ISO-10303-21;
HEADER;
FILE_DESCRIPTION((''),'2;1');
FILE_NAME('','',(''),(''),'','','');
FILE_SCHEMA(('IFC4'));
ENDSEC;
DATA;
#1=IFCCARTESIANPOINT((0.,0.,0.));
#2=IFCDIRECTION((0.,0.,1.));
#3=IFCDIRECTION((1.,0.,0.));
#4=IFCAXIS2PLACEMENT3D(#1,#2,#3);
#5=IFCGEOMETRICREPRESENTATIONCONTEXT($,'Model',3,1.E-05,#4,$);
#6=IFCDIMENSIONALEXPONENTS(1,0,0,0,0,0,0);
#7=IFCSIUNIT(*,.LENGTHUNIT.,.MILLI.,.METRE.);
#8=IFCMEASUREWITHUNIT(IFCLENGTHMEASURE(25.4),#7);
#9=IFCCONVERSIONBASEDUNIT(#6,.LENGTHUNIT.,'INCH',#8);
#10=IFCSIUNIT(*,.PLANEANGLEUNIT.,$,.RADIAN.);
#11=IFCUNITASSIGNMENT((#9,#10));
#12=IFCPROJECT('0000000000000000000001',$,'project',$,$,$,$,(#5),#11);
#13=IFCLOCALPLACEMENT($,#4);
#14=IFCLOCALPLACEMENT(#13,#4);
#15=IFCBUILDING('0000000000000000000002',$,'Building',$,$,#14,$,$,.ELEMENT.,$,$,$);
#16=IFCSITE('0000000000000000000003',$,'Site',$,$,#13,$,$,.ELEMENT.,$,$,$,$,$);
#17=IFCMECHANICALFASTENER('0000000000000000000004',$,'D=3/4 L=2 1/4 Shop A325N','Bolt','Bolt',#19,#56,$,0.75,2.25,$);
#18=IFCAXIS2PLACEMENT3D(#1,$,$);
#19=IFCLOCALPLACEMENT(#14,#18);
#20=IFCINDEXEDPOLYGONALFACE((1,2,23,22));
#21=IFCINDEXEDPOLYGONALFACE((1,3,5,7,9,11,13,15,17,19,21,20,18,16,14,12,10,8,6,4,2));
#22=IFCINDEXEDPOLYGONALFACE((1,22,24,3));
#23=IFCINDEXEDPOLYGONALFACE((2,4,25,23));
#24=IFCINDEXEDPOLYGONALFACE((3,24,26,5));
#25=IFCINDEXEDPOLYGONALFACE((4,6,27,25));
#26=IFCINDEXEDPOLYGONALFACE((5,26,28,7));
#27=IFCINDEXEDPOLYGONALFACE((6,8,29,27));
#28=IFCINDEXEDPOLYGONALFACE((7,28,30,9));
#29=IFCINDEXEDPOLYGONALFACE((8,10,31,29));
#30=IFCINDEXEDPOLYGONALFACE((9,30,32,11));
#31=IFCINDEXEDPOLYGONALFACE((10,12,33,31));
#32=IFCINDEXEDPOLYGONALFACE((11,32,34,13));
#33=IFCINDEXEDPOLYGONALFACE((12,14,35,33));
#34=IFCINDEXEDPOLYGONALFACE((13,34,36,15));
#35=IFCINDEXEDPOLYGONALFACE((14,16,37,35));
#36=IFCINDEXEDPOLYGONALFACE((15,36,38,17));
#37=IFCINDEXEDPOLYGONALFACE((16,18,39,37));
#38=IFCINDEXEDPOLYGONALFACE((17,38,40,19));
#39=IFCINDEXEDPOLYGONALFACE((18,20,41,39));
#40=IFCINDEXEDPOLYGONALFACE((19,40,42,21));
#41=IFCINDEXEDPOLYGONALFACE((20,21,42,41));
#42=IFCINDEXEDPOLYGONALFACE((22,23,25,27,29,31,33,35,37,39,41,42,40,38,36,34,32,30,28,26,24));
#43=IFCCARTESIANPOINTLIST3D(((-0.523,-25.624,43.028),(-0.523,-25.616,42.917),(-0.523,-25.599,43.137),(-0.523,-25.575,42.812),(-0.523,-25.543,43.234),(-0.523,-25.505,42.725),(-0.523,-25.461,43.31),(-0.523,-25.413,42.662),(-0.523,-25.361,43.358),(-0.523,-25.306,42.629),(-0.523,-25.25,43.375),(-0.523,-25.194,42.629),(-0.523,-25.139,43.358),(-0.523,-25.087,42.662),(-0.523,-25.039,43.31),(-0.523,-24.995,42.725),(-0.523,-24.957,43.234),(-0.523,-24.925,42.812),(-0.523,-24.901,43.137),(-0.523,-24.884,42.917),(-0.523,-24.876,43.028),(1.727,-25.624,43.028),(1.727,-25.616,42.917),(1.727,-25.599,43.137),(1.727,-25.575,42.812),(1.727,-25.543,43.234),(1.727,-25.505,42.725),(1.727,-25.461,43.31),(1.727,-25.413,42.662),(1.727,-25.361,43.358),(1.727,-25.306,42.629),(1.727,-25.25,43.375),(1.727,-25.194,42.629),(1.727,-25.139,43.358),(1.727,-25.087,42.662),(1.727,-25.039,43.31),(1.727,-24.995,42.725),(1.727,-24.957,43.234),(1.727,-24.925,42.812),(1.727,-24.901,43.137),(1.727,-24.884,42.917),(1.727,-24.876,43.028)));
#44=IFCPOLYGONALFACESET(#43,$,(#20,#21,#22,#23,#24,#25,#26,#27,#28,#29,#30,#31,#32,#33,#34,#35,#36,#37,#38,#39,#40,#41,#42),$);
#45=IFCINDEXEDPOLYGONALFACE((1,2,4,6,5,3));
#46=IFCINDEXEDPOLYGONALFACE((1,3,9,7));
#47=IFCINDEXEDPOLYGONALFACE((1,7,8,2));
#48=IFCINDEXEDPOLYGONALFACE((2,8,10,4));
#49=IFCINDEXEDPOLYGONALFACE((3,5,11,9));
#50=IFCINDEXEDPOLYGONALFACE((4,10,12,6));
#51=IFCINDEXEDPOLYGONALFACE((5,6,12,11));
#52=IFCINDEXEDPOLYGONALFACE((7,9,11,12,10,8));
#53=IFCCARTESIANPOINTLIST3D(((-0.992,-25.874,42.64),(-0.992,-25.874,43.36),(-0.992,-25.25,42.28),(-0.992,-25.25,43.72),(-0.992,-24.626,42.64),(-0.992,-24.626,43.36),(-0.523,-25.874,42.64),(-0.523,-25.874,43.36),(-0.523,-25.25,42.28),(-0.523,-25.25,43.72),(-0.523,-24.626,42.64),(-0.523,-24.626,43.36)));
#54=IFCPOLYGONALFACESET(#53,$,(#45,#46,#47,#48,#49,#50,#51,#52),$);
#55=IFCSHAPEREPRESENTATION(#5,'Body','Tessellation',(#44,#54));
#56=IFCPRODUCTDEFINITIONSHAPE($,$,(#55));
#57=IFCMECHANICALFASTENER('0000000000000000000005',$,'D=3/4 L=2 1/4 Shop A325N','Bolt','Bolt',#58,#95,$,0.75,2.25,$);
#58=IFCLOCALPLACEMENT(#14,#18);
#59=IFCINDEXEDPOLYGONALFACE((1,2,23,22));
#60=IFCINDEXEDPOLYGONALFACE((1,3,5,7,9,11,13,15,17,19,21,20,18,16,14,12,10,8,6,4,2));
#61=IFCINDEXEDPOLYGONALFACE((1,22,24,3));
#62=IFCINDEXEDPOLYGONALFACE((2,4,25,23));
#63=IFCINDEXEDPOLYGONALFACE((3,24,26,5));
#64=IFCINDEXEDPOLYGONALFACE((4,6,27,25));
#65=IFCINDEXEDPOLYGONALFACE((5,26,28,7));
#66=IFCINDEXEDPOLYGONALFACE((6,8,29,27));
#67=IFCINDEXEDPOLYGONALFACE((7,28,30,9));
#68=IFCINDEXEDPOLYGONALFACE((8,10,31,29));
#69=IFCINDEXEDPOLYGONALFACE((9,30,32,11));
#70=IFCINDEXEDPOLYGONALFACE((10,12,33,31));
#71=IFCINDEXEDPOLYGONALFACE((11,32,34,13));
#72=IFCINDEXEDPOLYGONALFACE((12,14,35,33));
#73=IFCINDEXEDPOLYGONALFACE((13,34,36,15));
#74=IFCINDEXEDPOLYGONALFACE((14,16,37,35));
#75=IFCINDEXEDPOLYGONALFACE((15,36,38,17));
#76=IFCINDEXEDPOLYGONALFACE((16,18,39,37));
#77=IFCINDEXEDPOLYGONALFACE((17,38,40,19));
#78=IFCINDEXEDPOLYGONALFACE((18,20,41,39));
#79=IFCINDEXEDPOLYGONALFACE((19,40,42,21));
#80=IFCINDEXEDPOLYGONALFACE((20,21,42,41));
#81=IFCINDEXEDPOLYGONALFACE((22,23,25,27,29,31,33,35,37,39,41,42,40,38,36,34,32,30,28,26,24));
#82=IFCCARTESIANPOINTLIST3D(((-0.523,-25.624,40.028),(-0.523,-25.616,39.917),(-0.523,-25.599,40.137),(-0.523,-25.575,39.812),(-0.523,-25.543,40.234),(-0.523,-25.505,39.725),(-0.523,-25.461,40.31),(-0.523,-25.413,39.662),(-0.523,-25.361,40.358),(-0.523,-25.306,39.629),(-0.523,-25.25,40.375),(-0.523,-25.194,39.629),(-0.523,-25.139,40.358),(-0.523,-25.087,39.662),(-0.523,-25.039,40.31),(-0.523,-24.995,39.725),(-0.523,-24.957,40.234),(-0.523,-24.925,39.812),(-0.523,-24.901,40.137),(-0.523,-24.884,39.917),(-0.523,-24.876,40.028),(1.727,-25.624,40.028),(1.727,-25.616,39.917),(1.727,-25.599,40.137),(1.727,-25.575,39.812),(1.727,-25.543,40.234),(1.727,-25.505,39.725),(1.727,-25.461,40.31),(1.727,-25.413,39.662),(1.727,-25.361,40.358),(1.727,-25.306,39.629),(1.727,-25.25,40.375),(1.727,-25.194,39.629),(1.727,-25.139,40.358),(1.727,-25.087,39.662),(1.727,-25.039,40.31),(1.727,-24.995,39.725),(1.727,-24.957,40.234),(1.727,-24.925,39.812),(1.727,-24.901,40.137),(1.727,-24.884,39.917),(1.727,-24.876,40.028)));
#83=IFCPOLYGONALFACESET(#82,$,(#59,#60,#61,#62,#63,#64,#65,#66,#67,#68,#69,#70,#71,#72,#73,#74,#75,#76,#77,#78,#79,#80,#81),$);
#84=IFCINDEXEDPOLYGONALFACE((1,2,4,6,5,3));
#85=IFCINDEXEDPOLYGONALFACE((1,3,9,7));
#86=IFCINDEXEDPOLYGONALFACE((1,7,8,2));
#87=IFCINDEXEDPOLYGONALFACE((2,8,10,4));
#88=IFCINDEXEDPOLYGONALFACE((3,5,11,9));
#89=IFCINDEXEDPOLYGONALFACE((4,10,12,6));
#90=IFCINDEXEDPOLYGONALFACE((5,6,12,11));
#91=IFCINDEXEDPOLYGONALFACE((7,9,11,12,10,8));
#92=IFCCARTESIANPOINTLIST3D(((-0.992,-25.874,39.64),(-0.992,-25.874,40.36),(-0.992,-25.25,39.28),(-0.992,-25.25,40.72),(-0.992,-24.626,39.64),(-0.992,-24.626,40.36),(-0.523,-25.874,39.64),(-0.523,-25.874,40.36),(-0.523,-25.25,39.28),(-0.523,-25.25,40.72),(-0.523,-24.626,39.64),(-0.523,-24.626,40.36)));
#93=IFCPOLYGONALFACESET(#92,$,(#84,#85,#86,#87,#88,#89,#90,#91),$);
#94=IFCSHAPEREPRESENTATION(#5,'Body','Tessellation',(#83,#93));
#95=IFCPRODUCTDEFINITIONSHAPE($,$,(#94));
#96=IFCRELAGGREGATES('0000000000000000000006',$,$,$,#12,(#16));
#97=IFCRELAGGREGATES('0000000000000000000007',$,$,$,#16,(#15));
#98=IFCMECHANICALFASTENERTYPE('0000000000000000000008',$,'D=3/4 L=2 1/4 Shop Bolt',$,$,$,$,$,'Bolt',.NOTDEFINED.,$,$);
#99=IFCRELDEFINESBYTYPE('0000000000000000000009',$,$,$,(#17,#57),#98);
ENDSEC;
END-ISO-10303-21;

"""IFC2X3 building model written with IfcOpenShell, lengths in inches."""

from ifc_helpers import new_model, entity, si_unit, converted_unit, frame, origin_with_axes, origin_2d_with_axis, place, context, project, spatial, polyline, circle, outline, extrude, source, transform, mapped, type_object, type_shapes, element, save


model = new_model("IFC2X3")

# Units and contexts
model_context = context("Model", 3, precision=1e-05, world=origin_with_axes())
ifc_project = project(units=[converted_unit("LENGTHUNIT", "INCH", entity("IfcLengthMeasure", 25.4), si_unit("LENGTHUNIT", "METRE", prefix="MILLI"), dimensions=[1, 0, 0, 0, 0, 0, 0]), si_unit("PLANEANGLEUNIT", "RADIAN")], contexts=[model_context])

# Site, building
site_placement = place(None, origin_with_axes())
site = spatial("IfcSite", under=ifc_project, at=site_placement, Name="Site", CompositionType="ELEMENT")
building_placement = place(site_placement, origin_with_axes())
building = spatial("IfcBuilding", under=site, at=building_placement, Name="Building", CompositionType="ELEMENT")

# Shared definitions
assembly_1_placement = place(building_placement, frame((0.0, 0.0, 46.0), z_axis=(0.0, 0.0, 1.0), x_axis=(0.0, -1.0, 0.0)))

# Mechanical fasteners
mechanical_fastener_type_1 = type_object("IfcMechanicalFastenerType", Name="D=3/4 L=2 1/4 Shop Bolt", ElementType="Bolt")
shared_shape_1 = source(origin_with_axes(), model_context, "Body", "SweptSolid", [
    extrude(circle(Radius=0.375, at=origin_2d_with_axis()), frame((0.0, 0.0, 0.0), z_axis=(1.0, 0.0, 0.0), x_axis=(0.0, 1.0, 0.0)), (0.0, 0.0, 1.0), 2.25),
    extrude(outline(polyline([(-0.72, 0.0), (-0.36, 0.624), (0.36, 0.624), (0.72, 0.0), (0.36, -0.624), (-0.36, -0.624), (-0.72, 0.0)])), frame((0.0, 0.0, 0.0), z_axis=(1.0, 0.0, 0.0), x_axis=(0.0, 1.0, 0.0)), (0.0, 0.0, -1.0), 0.47),
])
type_shapes(mechanical_fastener_type_1, [shared_shape_1])
placement_1 = place(assembly_1_placement, frame((25.25, -0.523, -3.0), z_axis=(1.0, 0.0, 0.0), x_axis=(0.0, 1.0, 0.0)))
for number, where, z_axis, x_axis, name in (
    (1, (0.0, 0.0, 0.0), (0.0, 0.0, 1.0), (1.0, 0.0, 0.0), "D=3/4 L=2 1/4 Shop A325N"),
    (2, (0.0, -3.0, 0.0), (0.0, 0.0, 1.0), (1.0, 0.0, 0.0), "D=3/4 L=2 1/4 Shop A325N"),
):
    element("IfcMechanicalFastener", number, at=place(placement_1, frame(where, z_axis=z_axis, x_axis=x_axis)), type_object=mechanical_fastener_type_1, Name=name, Description="Bolt", ObjectType="Bolt", NominalDiameter=0.75, NominalLength=2.25, context=model_context, shape_type="MappedRepresentation", body=[
        mapped(shared_shape_1, transform((0.0, 0.0, 0.0), scale=1.0)),
    ])

save(model, "model.ifc")
